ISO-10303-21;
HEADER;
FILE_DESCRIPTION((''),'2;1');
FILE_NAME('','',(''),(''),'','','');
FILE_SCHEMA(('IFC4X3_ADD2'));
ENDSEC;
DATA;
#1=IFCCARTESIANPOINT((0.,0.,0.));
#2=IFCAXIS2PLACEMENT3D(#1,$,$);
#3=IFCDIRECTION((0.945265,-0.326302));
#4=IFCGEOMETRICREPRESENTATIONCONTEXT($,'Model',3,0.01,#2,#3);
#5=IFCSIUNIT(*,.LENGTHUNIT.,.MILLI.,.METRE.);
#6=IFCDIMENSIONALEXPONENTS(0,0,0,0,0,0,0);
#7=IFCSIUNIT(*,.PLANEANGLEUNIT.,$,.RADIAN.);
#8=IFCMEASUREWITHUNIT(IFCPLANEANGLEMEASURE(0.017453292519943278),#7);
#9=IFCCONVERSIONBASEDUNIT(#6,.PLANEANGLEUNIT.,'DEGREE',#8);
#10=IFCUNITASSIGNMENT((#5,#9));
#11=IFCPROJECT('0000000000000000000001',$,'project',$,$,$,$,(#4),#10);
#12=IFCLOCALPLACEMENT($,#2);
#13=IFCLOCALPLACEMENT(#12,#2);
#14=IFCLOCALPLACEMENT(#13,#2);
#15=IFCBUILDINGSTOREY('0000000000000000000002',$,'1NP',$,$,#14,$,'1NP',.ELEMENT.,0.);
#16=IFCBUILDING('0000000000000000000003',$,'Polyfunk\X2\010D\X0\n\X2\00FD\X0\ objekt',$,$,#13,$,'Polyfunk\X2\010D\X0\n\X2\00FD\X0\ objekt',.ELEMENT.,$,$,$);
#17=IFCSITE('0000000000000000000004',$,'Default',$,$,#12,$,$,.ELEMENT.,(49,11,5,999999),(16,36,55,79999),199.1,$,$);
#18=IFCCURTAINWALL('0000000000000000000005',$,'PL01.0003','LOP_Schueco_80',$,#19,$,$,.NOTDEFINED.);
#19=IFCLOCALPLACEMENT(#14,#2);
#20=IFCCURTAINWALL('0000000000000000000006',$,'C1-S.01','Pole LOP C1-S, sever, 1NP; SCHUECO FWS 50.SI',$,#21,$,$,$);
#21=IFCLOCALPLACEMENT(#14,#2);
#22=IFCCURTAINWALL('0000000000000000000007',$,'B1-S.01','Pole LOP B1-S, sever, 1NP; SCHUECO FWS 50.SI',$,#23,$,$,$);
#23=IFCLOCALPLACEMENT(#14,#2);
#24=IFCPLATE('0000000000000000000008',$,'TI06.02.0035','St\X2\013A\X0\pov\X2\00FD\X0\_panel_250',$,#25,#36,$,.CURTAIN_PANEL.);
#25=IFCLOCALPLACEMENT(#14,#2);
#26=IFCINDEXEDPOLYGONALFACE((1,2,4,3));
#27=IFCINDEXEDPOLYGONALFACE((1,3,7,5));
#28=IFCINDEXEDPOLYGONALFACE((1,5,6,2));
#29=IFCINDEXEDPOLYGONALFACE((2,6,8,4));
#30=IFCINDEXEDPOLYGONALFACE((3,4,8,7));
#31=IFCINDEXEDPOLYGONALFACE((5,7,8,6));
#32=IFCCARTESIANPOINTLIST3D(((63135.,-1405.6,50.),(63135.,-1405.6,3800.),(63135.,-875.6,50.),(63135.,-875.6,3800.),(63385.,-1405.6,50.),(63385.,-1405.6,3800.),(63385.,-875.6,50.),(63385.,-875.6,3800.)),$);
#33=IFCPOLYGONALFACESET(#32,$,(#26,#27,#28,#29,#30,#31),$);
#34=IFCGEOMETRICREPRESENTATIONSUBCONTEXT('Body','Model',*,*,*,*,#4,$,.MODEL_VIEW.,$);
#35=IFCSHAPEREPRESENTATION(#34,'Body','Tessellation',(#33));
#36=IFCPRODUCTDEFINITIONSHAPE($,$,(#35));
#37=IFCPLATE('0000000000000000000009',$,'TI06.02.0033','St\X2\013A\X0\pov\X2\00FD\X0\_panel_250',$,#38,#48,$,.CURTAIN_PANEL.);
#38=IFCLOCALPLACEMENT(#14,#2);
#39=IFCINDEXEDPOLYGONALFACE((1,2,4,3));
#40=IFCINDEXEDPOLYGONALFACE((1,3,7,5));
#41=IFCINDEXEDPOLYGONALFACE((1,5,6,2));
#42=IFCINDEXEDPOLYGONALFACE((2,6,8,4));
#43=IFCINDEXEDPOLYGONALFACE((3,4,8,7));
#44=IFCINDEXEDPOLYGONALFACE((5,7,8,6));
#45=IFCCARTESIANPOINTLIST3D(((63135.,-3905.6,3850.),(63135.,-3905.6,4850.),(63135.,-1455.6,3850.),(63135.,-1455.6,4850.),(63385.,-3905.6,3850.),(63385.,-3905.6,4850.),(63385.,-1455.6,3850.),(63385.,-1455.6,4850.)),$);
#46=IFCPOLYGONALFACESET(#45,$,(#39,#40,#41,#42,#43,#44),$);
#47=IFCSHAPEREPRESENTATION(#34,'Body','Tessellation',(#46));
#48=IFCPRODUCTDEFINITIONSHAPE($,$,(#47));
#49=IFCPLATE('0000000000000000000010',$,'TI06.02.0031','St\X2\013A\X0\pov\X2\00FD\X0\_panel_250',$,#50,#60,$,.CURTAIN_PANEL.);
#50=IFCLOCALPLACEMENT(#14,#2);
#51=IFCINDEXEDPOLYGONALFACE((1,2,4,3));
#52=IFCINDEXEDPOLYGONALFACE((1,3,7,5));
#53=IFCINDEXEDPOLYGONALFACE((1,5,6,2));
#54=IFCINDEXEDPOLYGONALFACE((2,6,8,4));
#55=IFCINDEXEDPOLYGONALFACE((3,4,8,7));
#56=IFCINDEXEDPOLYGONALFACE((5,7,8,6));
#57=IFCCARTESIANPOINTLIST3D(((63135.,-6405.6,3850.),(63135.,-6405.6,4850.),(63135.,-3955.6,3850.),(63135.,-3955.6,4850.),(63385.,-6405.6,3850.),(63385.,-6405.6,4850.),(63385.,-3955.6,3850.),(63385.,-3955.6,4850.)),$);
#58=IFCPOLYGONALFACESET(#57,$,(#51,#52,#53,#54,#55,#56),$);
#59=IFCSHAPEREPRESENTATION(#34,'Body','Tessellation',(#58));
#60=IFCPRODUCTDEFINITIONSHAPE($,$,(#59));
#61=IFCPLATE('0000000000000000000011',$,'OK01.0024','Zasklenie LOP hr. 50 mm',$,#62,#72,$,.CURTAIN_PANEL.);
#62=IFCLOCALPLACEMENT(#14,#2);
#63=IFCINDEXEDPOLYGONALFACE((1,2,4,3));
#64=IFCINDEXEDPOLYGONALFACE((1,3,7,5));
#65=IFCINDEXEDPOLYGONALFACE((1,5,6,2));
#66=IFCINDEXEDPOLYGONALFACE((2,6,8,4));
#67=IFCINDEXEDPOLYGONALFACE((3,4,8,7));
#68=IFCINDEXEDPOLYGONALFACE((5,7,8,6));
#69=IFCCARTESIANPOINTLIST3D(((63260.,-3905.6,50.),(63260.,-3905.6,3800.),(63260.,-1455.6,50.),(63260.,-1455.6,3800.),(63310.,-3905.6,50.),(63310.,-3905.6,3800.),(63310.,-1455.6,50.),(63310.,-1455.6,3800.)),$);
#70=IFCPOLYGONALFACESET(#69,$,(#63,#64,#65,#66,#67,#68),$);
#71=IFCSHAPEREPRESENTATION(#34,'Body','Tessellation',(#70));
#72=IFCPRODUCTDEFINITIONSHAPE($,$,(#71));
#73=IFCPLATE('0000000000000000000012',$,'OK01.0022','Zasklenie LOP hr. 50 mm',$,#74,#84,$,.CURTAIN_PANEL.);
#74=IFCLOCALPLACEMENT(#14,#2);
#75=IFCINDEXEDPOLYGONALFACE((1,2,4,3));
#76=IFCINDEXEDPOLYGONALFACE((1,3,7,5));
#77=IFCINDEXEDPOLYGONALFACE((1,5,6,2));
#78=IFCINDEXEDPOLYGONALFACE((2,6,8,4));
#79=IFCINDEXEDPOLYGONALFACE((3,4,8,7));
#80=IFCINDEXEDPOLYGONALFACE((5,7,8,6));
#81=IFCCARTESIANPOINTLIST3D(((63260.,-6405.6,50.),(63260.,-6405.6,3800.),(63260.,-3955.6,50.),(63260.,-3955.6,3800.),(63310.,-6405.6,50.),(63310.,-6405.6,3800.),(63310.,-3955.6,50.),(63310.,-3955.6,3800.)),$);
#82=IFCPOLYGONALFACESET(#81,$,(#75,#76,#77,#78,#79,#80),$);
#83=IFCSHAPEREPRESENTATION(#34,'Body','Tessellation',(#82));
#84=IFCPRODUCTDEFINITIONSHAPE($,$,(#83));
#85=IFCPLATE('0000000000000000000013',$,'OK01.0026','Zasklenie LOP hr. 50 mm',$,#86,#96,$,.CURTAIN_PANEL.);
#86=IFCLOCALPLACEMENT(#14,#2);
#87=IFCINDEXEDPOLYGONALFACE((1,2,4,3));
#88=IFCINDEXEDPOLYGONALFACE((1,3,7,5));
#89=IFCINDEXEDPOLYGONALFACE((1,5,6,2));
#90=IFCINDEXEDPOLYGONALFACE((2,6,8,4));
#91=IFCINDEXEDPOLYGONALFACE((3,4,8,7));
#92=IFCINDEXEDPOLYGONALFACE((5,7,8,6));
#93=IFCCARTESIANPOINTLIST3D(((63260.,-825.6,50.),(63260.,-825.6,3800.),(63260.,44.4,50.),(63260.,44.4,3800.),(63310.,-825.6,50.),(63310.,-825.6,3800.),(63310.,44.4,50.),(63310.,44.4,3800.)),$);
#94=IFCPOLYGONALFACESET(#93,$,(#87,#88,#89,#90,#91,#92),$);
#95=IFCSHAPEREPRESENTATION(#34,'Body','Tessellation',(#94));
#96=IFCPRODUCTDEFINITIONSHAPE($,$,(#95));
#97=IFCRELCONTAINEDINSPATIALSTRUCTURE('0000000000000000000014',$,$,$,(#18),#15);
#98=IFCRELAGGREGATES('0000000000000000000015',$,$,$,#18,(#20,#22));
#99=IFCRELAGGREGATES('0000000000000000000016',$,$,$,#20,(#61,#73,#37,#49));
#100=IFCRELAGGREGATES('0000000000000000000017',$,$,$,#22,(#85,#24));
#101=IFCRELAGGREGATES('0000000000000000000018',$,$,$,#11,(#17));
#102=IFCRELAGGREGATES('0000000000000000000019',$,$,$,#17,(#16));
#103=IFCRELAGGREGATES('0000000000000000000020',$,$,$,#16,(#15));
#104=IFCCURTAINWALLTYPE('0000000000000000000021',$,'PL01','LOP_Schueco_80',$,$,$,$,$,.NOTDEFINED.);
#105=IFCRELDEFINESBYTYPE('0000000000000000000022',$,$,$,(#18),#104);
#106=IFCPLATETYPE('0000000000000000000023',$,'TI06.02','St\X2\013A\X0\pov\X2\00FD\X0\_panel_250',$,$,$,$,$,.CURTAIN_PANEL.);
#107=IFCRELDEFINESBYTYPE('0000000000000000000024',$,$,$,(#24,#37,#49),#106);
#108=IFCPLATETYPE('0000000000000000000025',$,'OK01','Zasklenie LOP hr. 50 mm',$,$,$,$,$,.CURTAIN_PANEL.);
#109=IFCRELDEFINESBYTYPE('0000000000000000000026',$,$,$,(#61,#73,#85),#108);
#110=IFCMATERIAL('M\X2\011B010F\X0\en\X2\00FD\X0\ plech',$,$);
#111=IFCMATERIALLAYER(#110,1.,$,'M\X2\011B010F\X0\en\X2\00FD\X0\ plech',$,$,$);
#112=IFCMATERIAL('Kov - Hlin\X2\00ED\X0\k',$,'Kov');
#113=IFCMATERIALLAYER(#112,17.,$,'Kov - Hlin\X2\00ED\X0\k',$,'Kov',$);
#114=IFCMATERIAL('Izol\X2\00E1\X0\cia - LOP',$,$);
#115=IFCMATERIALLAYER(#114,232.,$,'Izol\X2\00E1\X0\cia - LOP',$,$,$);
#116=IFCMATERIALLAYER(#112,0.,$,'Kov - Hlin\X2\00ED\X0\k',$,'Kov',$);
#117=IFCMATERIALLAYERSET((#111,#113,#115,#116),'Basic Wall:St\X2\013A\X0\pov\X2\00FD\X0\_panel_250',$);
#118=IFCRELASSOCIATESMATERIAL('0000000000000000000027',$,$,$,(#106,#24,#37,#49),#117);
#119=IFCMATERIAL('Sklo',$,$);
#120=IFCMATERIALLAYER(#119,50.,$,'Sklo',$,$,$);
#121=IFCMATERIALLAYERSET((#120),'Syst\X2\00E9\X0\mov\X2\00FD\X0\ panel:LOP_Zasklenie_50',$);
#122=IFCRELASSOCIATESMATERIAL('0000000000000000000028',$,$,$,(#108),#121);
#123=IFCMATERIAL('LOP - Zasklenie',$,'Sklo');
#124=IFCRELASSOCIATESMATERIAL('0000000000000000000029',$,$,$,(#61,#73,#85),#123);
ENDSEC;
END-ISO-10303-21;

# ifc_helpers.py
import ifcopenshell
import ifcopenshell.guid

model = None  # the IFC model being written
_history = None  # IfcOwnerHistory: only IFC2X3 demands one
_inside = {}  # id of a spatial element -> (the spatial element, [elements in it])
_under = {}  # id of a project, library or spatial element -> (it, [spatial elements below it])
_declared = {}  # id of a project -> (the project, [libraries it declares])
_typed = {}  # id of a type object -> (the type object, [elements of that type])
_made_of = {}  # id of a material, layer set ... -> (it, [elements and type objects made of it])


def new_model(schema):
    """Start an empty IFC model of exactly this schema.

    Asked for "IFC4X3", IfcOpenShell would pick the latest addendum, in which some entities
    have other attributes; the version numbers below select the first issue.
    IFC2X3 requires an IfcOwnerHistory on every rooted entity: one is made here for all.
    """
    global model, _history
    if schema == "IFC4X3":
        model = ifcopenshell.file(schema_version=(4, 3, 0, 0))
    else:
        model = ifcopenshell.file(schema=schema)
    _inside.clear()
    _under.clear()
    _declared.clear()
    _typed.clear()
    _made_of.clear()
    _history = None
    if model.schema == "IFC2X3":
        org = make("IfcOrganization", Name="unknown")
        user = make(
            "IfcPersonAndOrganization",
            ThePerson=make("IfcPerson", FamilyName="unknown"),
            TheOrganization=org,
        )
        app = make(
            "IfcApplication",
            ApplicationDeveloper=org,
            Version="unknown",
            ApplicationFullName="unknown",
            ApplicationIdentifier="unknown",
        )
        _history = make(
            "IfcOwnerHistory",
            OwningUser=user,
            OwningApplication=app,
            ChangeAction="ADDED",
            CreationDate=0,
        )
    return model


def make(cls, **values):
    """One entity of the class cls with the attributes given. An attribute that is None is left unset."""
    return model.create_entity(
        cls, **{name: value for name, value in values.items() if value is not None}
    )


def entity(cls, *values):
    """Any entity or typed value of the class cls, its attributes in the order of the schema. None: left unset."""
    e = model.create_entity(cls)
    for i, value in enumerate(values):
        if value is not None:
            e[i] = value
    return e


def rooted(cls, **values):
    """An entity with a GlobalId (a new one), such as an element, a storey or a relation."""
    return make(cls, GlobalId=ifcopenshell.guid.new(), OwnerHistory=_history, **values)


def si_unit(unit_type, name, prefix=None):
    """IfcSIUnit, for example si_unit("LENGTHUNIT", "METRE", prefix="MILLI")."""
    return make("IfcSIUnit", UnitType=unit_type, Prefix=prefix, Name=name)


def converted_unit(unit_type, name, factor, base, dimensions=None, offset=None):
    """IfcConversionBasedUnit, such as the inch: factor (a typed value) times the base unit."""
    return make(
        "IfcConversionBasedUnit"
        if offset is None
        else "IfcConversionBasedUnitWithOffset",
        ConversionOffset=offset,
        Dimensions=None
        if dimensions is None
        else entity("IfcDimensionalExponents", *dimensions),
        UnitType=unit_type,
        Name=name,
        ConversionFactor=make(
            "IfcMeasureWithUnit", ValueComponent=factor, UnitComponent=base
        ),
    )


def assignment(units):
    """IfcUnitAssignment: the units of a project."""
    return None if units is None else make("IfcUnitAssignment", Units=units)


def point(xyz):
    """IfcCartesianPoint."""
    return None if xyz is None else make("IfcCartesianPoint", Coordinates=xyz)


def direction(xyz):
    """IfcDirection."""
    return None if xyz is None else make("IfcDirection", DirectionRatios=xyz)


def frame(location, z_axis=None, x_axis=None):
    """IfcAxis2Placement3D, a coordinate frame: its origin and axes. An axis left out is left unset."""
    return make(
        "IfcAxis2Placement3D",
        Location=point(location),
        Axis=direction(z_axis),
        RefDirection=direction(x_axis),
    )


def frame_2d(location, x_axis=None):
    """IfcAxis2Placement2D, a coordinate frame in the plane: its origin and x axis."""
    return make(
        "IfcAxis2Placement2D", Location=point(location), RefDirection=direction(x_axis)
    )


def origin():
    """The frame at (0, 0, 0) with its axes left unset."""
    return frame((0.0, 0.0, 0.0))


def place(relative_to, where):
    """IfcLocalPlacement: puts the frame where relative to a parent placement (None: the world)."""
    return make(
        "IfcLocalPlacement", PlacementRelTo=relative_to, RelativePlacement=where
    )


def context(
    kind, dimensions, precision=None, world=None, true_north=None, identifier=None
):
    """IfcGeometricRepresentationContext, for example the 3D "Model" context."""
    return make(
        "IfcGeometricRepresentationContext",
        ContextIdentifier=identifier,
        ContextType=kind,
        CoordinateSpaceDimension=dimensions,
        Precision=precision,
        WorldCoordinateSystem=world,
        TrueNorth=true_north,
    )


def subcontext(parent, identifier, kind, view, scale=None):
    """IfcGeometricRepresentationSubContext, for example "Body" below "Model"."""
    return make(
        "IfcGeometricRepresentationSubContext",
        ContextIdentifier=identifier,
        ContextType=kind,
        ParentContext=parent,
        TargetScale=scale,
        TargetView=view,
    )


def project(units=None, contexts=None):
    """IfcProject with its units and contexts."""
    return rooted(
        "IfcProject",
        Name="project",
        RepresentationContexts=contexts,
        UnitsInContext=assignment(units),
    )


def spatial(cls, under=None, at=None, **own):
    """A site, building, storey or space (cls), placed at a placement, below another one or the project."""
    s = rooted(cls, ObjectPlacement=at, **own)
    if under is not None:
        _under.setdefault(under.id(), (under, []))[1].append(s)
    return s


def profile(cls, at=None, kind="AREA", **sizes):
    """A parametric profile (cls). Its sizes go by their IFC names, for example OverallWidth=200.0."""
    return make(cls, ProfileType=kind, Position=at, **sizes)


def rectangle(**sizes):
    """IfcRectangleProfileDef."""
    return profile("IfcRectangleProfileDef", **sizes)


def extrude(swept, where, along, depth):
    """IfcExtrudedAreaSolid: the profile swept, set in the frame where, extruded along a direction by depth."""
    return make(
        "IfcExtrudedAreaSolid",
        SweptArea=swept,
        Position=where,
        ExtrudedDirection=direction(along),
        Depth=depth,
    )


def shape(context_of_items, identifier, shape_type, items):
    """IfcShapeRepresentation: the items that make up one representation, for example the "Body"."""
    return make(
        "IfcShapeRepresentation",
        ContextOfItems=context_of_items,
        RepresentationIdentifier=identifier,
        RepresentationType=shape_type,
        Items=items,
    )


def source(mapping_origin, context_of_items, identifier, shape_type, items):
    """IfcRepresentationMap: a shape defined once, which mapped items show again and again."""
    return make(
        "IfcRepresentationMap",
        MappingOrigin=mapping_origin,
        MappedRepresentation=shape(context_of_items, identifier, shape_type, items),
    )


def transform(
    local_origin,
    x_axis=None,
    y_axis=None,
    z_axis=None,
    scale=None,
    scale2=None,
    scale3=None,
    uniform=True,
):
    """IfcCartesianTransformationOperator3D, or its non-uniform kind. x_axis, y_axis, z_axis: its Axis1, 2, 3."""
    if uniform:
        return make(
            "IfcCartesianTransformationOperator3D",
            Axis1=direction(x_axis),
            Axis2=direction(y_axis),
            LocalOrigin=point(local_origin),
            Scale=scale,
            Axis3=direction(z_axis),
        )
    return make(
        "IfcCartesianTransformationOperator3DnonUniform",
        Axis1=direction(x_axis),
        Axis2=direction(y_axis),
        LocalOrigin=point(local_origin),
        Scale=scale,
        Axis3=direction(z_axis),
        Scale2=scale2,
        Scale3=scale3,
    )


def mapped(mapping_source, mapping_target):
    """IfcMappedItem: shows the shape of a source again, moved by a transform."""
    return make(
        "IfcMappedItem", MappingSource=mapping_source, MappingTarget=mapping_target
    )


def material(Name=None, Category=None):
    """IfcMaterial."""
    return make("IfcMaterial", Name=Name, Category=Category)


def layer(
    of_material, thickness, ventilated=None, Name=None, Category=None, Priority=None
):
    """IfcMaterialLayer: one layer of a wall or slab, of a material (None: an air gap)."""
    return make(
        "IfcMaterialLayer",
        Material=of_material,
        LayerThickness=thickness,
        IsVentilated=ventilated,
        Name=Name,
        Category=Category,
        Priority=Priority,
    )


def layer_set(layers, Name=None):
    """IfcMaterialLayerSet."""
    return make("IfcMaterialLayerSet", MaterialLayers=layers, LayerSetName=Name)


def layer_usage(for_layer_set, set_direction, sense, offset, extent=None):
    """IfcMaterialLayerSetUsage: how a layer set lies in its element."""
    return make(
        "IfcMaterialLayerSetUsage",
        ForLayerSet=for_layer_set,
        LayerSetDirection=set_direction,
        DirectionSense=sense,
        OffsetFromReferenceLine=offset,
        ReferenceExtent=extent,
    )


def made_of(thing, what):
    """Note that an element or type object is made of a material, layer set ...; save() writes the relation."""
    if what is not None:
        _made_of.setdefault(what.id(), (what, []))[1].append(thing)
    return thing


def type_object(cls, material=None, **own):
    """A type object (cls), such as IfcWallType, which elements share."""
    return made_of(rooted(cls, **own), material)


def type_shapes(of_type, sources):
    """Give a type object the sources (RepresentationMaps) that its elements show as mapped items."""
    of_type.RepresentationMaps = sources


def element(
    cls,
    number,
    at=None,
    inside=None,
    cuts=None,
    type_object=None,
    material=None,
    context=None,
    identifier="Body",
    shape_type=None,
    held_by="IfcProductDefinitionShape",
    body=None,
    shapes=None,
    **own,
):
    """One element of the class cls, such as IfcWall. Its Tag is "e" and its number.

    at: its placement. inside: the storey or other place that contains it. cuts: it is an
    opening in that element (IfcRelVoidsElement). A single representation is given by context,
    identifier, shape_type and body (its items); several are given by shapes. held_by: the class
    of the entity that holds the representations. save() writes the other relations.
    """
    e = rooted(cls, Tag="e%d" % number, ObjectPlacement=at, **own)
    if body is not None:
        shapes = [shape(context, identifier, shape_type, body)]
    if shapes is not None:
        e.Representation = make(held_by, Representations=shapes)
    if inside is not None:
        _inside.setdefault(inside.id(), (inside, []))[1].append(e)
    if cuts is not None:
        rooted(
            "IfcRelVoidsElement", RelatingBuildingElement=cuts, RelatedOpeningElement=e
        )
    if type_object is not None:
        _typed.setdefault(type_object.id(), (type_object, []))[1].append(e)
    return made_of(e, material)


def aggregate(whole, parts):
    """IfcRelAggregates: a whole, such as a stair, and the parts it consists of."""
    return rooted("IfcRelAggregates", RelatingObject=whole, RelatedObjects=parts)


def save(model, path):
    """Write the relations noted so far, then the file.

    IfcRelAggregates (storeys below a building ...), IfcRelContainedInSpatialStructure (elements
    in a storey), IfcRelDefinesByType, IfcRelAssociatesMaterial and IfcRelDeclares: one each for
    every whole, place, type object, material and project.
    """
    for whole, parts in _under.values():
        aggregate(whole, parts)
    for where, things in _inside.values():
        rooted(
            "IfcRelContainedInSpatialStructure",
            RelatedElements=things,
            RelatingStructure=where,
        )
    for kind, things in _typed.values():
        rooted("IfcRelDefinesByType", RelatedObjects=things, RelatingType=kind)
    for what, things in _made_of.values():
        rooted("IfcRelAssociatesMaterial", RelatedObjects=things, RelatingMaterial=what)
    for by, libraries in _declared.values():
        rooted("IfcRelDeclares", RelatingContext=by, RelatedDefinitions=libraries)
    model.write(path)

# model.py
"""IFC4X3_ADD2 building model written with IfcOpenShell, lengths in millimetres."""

from ifc_helpers import new_model, entity, si_unit, converted_unit, direction, frame, frame_2d, origin, place, context, subcontext, project, spatial, rectangle, extrude, source, transform, mapped, material, layer, layer_set, layer_usage, type_object, type_shapes, element, aggregate, save


model = new_model("IFC4X3_ADD2")

# Units and contexts
model_context = context("Model", 3, precision=0.01, world=origin(), true_north=direction((0.945265, -0.326302)))
body_context = subcontext(model_context, "Body", "Model", "MODEL_VIEW")
ifc_project = project(units=[si_unit("LENGTHUNIT", "METRE", prefix="MILLI"), converted_unit("PLANEANGLEUNIT", "DEGREE", entity("IfcPlaneAngleMeasure", 0.017453292519943278), si_unit("PLANEANGLEUNIT", "RADIAN"), dimensions=[0, 0, 0, 0, 0, 0, 0])], contexts=[model_context])

# Site, building, storey
site_placement = place(None, origin())
site = spatial("IfcSite", under=ifc_project, at=site_placement, Name="Default", CompositionType="ELEMENT", RefLatitude=(49, 11, 5, 999999), RefLongitude=(16, 36, 55, 79999), RefElevation=199.1)
building_placement = place(site_placement, origin())
building = spatial("IfcBuilding", under=site, at=building_placement, Name="Polyfunkčný objekt", LongName="Polyfunkčný objekt", CompositionType="ELEMENT")
storey_placement = place(building_placement, origin())
storey = spatial("IfcBuildingStorey", under=building, at=storey_placement, Name="1NP", LongName="1NP", CompositionType="ELEMENT", Elevation=0.0)

# Curtain walls, plates
curtain_wall_type = type_object("IfcCurtainWallType", Name="PL01", Description="LOP_Schueco_80", PredefinedType="NOTDEFINED")
curtain_wall_1_placement = place(storey_placement, origin())
curtain_wall_1 = element("IfcCurtainWall", 1, at=curtain_wall_1_placement, inside=storey, type_object=curtain_wall_type, Name="PL01.0003", Description="LOP_Schueco_80", PredefinedType="NOTDEFINED")
curtain_wall_2 = element("IfcCurtainWall", 2, Name="C1-S.01", Description="Pole LOP C1-S, sever, 1NP; SCHUECO FWS 50.SI")
curtain_wall_3 = element("IfcCurtainWall", 3, Name="B1-S.01", Description="Pole LOP B1-S, sever, 1NP; SCHUECO FWS 50.SI")
aggregate(curtain_wall_1, [curtain_wall_2, curtain_wall_3])
ifc_material_1 = material(Name="Měďený plech")
ifc_layer_1 = layer(ifc_material_1, 1.0, Name="Měďený plech")
ifc_material_2 = material(Name="Kov - Hliník", Category="Kov")
ifc_layer_2 = layer(ifc_material_2, 17.0, Name="Kov - Hliník", Category="Kov")
ifc_material_3 = material(Name="Izolácia - LOP")
ifc_layer_3 = layer(ifc_material_3, 232.0, Name="Izolácia - LOP")
ifc_layer_4 = layer(ifc_material_2, 0.0, Name="Kov - Hliník", Category="Kov")
ifc_layer_set_1 = layer_set([ifc_layer_1, ifc_layer_2, ifc_layer_3, ifc_layer_4], Name="Basic Wall:Stĺpový_panel_250")
ifc_layer_usage_1 = layer_usage(ifc_layer_set_1, "AXIS2", "NEGATIVE", 125.0)
plate_type_1 = type_object("IfcPlateType", Name="TI06.02", Description="Stĺpový_panel_250", PredefinedType="CURTAIN_PANEL", material=ifc_layer_set_1)
plate_1_placement = place(storey_placement, frame((63260.0, -875.6, 50.0), z_axis=(0.0, 0.0, 1.0), x_axis=(0.0, -1.0, 0.0)))
plate_1 = element("IfcPlate", 4, at=plate_1_placement, type_object=plate_type_1, material=ifc_layer_usage_1, Name="TI06.02.0035", Description="Stĺpový_panel_250", PredefinedType="CURTAIN_PANEL", context=body_context, shape_type="SweptSolid", body=[
    extrude(rectangle(XDim=250.0, YDim=530.0, at=frame_2d((0.0, 0.0), x_axis=(1.0, 0.0))), frame((265.0, 0.0, 0.0), z_axis=(0.0, 0.0, 1.0), x_axis=(0.0, 1.0, 0.0)), (0.0, 0.0, 1.0), 3750.0),
])
ifc_layer_usage_2 = layer_usage(ifc_layer_set_1, "AXIS2", "NEGATIVE", 125.0)
plate_2_placement = place(storey_placement, frame((63260.0, -1455.6, 3850.0), z_axis=(0.0, 0.0, 1.0), x_axis=(0.0, -1.0, 0.0)))
plate_2 = element("IfcPlate", 5, at=plate_2_placement, type_object=plate_type_1, material=ifc_layer_usage_2, Name="TI06.02.0033", Description="Stĺpový_panel_250", PredefinedType="CURTAIN_PANEL", context=body_context, shape_type="SweptSolid", body=[
    extrude(rectangle(XDim=250.0, YDim=2450.0, at=frame_2d((0.0, 0.0), x_axis=(1.0, 0.0))), frame((1225.0, 0.0, 0.0), z_axis=(0.0, 0.0, 1.0), x_axis=(0.0, 1.0, 0.0)), (0.0, 0.0, 1.0), 1000.0),
])
ifc_layer_usage_3 = layer_usage(ifc_layer_set_1, "AXIS2", "NEGATIVE", 125.0)
plate_3_placement = place(storey_placement, frame((63260.0, -3955.6, 3850.0), z_axis=(0.0, 0.0, 1.0), x_axis=(0.0, -1.0, 0.0)))
plate_3 = element("IfcPlate", 6, at=plate_3_placement, type_object=plate_type_1, material=ifc_layer_usage_3, Name="TI06.02.0031", Description="Stĺpový_panel_250", PredefinedType="CURTAIN_PANEL", context=body_context, shape_type="SweptSolid", body=[
    extrude(rectangle(XDim=250.0, YDim=2450.0, at=frame_2d((0.0, 0.0), x_axis=(1.0, 0.0))), frame((1225.0, 0.0, 0.0), z_axis=(0.0, 0.0, 1.0), x_axis=(0.0, 1.0, 0.0)), (0.0, 0.0, 1.0), 1000.0),
])
ifc_material_4 = material(Name="LOP - Zasklenie", Category="Sklo")
ifc_material_5 = material(Name="Sklo")
ifc_layer_5 = layer(ifc_material_5, 50.0, Name="Sklo")
ifc_layer_set_2 = layer_set([ifc_layer_5], Name="Systémový panel:LOP_Zasklenie_50")
plate_type_2 = type_object("IfcPlateType", Name="OK01", Description="Zasklenie LOP hr. 50 mm", PredefinedType="CURTAIN_PANEL", material=ifc_layer_set_2)
shared_shape_1 = source(origin(), body_context, "Body", "SweptSolid", [
    extrude(rectangle(XDim=3750.0, YDim=2450.0, at=frame_2d((-141.7, 0.0), x_axis=(1.0, 0.0))), frame((0.0, 0.0, 2016.7), z_axis=(0.0, 1.0, 0.0), x_axis=(0.0, 0.0, 1.0)), (0.0, 0.0, 1.0), 50.0),
])
plate_4_placement = place(curtain_wall_1_placement, frame((63260.0, -2680.6, 50.0), z_axis=(0.0, 0.0, 1.0), x_axis=(0.0, -1.0, 0.0)))
plate_4 = element("IfcPlate", 7, at=plate_4_placement, type_object=plate_type_2, material=ifc_material_4, Name="OK01.0024", Description="Zasklenie LOP hr. 50 mm", PredefinedType="CURTAIN_PANEL", context=body_context, shape_type="MappedRepresentation", body=[
    mapped(shared_shape_1, transform((0.0, 0.0, 0.0), scale=1.0)),
])
plate_5_placement = place(curtain_wall_1_placement, frame((63260.0, -5180.6, 50.0), z_axis=(0.0, 0.0, 1.0), x_axis=(0.0, -1.0, 0.0)))
plate_5 = element("IfcPlate", 8, at=plate_5_placement, type_object=plate_type_2, material=ifc_material_4, Name="OK01.0022", Description="Zasklenie LOP hr. 50 mm", PredefinedType="CURTAIN_PANEL", context=body_context, shape_type="MappedRepresentation", body=[
    mapped(shared_shape_1, transform((0.0, 0.0, 0.0), scale=1.0)),
])
aggregate(curtain_wall_2, [plate_4, plate_5, plate_2, plate_3])
shared_shape_2 = source(origin(), body_context, "Body", "SweptSolid", [
    extrude(rectangle(XDim=3750.0, YDim=870.0, at=frame_2d((-141.7, 0.0), x_axis=(1.0, 0.0))), frame((0.0, 0.0, 2016.7), z_axis=(0.0, 1.0, 0.0), x_axis=(0.0, 0.0, 1.0)), (0.0, 0.0, 1.0), 50.0),
])
type_shapes(plate_type_2, [shared_shape_1, shared_shape_2])
plate_6_placement = place(curtain_wall_1_placement, frame((63260.0, -390.6, 50.0), z_axis=(0.0, 0.0, 1.0), x_axis=(0.0, -1.0, 0.0)))
plate_6 = element("IfcPlate", 9, at=plate_6_placement, type_object=plate_type_2, material=ifc_material_4, Name="OK01.0026", Description="Zasklenie LOP hr. 50 mm", PredefinedType="CURTAIN_PANEL", context=body_context, shape_type="MappedRepresentation", body=[
    mapped(shared_shape_2, transform((0.0, 0.0, 0.0), scale=1.0)),
])
aggregate(curtain_wall_3, [plate_6, plate_1])

save(model, "model.ifc")
